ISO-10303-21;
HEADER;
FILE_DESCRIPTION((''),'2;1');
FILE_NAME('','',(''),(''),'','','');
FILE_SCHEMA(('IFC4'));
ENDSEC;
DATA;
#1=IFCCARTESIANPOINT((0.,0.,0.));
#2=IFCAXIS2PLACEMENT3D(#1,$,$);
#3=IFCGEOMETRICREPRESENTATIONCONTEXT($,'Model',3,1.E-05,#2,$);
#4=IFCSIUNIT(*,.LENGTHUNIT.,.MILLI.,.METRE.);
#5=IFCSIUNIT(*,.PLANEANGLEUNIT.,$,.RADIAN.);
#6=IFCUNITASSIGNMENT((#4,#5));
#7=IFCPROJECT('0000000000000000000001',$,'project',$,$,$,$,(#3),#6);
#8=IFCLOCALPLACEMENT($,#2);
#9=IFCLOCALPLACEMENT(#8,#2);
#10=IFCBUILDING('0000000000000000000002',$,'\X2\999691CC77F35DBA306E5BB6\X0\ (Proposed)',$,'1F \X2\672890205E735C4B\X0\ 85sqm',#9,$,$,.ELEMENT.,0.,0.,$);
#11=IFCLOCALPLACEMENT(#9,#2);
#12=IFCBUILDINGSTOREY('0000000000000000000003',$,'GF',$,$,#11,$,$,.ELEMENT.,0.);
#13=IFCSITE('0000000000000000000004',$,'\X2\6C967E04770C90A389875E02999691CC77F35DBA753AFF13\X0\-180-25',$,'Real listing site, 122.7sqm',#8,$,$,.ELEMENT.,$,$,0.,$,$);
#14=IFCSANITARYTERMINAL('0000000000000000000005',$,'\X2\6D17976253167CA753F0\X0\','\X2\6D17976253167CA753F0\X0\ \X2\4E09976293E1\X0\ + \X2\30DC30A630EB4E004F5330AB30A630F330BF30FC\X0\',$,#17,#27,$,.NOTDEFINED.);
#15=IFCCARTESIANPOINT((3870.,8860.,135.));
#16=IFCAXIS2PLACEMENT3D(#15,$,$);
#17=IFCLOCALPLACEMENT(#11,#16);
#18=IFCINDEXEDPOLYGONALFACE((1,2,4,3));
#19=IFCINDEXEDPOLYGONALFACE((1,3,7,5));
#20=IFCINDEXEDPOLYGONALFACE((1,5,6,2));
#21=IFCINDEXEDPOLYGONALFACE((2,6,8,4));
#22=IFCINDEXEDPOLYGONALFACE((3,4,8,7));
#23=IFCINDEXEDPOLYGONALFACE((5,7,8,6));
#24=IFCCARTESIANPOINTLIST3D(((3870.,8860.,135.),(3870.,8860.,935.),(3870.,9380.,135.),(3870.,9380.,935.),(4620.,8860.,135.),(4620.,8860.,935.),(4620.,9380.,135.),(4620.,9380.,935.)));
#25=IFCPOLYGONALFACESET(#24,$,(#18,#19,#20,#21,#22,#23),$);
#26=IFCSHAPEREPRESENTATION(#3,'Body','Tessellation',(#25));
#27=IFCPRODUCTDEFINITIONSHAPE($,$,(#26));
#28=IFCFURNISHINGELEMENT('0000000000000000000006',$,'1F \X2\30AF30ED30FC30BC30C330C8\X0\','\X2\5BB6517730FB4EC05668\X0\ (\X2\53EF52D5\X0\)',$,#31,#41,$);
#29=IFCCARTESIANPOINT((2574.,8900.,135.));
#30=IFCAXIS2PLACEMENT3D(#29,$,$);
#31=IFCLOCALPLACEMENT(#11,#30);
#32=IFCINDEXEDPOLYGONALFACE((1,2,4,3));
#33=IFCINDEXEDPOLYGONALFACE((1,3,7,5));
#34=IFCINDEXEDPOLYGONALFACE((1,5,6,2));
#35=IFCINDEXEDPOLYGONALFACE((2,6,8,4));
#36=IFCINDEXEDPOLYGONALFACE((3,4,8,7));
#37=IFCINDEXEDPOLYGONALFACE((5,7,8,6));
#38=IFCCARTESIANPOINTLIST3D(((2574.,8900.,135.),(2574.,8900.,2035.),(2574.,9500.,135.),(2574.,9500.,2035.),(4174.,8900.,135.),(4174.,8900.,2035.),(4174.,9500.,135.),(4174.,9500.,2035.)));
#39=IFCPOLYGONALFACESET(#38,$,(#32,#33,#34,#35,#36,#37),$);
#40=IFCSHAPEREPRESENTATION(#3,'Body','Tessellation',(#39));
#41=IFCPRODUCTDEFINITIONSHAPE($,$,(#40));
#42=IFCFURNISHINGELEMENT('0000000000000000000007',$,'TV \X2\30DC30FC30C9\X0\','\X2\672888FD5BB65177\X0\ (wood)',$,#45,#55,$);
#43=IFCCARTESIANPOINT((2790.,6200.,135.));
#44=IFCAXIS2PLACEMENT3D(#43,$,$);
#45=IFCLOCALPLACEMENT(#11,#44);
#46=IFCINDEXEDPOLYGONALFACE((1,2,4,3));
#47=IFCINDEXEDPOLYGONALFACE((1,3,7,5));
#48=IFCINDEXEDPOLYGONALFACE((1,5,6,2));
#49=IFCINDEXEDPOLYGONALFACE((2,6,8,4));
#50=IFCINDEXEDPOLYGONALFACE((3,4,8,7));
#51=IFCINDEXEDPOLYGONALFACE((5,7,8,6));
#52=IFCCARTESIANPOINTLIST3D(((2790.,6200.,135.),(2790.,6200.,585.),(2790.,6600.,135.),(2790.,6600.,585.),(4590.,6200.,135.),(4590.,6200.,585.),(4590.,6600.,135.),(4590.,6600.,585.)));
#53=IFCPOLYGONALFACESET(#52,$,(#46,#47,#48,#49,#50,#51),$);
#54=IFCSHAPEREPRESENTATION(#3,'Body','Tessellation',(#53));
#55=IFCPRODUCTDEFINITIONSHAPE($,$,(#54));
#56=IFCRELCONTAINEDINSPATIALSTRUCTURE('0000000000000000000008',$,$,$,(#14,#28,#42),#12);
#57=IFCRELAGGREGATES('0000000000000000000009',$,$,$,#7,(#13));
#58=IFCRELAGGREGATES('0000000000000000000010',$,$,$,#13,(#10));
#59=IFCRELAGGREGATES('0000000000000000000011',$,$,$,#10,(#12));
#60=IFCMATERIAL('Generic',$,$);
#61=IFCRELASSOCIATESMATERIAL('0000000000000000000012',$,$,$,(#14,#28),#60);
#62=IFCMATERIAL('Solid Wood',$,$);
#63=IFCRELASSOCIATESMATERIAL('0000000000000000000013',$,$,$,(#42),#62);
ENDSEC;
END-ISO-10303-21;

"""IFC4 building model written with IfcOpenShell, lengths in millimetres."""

from ifc_helpers import new_model, si_unit, frame, frame_2d, origin, place, context, project, spatial, rectangle, extrude, material, element, save


model = new_model("IFC4")

# Units and contexts
model_context = context("Model", 3, precision=1e-05, world=origin())
ifc_project = project(units=[si_unit("LENGTHUNIT", "METRE", prefix="MILLI"), si_unit("PLANEANGLEUNIT", "RADIAN")], contexts=[model_context])

# Site, building, storey
site_placement = place(None, origin())
site = spatial("IfcSite", under=ifc_project, at=site_placement, Name="沖縄県那覇市首里石嶺町３-180-25", ObjectType="Real listing site, 122.7sqm", CompositionType="ELEMENT", RefElevation=0.0)
building_placement = place(site_placement, origin())
building = spatial("IfcBuilding", under=site, at=building_placement, Name="首里石嶺の家 (Proposed)", ObjectType="1F 木造平屋 85sqm", CompositionType="ELEMENT", ElevationOfRefHeight=0.0, ElevationOfTerrain=0.0)
storey_placement = place(building_placement, origin())
storey = spatial("IfcBuildingStorey", under=building, at=storey_placement, Name="GF", CompositionType="ELEMENT", Elevation=0.0)

# Shared definitions
ifc_material_1 = material(Name="Solid Wood")

# Shared definitions
ifc_material_2 = material(Name="Generic")

# Sanitary terminal
sanitary_terminal_1_placement = place(storey_placement, frame((3870.0, 8860.0, 135.0)))
element("IfcSanitaryTerminal", 1, at=sanitary_terminal_1_placement, inside=storey, material=ifc_material_2, Name="洗面化粧台", Description="洗面化粧台 三面鏡 + ボウル一体カウンター", PredefinedType="NOTDEFINED", context=model_context, shape_type="SweptSolid", body=[
    extrude(rectangle(XDim=750.0, YDim=520.0, at=frame_2d((375.0, 260.0))), frame((3870.0, 8860.0, 135.0)), (0.0, 0.0, 1.0), 800.0),
])

# Furnishing elements
furnishing_1_placement = place(storey_placement, frame((2574.0, 8900.0, 135.0)))
element("IfcFurnishingElement", 2, at=furnishing_1_placement, inside=storey, material=ifc_material_2, Name="1F クローゼット", Description="家具・什器 (可動)", context=model_context, shape_type="SweptSolid", body=[
    extrude(rectangle(XDim=1600.0, YDim=600.0, at=frame_2d((800.0, 300.0))), frame((2574.0, 8900.0, 135.0)), (0.0, 0.0, 1.0), 1900.0),
])
furnishing_2_placement = place(storey_placement, frame((2790.0, 6200.0, 135.0)))
element("IfcFurnishingElement", 3, at=furnishing_2_placement, inside=storey, material=ifc_material_1, Name="TV ボード", Description="木製家具 (wood)", context=model_context, shape_type="SweptSolid", body=[
    extrude(rectangle(XDim=1800.0, YDim=400.0, at=frame_2d((900.0, 200.0))), frame((2790.0, 6200.0, 135.0)), (0.0, 0.0, 1.0), 450.0),
])

save(model, "model.ifc")
